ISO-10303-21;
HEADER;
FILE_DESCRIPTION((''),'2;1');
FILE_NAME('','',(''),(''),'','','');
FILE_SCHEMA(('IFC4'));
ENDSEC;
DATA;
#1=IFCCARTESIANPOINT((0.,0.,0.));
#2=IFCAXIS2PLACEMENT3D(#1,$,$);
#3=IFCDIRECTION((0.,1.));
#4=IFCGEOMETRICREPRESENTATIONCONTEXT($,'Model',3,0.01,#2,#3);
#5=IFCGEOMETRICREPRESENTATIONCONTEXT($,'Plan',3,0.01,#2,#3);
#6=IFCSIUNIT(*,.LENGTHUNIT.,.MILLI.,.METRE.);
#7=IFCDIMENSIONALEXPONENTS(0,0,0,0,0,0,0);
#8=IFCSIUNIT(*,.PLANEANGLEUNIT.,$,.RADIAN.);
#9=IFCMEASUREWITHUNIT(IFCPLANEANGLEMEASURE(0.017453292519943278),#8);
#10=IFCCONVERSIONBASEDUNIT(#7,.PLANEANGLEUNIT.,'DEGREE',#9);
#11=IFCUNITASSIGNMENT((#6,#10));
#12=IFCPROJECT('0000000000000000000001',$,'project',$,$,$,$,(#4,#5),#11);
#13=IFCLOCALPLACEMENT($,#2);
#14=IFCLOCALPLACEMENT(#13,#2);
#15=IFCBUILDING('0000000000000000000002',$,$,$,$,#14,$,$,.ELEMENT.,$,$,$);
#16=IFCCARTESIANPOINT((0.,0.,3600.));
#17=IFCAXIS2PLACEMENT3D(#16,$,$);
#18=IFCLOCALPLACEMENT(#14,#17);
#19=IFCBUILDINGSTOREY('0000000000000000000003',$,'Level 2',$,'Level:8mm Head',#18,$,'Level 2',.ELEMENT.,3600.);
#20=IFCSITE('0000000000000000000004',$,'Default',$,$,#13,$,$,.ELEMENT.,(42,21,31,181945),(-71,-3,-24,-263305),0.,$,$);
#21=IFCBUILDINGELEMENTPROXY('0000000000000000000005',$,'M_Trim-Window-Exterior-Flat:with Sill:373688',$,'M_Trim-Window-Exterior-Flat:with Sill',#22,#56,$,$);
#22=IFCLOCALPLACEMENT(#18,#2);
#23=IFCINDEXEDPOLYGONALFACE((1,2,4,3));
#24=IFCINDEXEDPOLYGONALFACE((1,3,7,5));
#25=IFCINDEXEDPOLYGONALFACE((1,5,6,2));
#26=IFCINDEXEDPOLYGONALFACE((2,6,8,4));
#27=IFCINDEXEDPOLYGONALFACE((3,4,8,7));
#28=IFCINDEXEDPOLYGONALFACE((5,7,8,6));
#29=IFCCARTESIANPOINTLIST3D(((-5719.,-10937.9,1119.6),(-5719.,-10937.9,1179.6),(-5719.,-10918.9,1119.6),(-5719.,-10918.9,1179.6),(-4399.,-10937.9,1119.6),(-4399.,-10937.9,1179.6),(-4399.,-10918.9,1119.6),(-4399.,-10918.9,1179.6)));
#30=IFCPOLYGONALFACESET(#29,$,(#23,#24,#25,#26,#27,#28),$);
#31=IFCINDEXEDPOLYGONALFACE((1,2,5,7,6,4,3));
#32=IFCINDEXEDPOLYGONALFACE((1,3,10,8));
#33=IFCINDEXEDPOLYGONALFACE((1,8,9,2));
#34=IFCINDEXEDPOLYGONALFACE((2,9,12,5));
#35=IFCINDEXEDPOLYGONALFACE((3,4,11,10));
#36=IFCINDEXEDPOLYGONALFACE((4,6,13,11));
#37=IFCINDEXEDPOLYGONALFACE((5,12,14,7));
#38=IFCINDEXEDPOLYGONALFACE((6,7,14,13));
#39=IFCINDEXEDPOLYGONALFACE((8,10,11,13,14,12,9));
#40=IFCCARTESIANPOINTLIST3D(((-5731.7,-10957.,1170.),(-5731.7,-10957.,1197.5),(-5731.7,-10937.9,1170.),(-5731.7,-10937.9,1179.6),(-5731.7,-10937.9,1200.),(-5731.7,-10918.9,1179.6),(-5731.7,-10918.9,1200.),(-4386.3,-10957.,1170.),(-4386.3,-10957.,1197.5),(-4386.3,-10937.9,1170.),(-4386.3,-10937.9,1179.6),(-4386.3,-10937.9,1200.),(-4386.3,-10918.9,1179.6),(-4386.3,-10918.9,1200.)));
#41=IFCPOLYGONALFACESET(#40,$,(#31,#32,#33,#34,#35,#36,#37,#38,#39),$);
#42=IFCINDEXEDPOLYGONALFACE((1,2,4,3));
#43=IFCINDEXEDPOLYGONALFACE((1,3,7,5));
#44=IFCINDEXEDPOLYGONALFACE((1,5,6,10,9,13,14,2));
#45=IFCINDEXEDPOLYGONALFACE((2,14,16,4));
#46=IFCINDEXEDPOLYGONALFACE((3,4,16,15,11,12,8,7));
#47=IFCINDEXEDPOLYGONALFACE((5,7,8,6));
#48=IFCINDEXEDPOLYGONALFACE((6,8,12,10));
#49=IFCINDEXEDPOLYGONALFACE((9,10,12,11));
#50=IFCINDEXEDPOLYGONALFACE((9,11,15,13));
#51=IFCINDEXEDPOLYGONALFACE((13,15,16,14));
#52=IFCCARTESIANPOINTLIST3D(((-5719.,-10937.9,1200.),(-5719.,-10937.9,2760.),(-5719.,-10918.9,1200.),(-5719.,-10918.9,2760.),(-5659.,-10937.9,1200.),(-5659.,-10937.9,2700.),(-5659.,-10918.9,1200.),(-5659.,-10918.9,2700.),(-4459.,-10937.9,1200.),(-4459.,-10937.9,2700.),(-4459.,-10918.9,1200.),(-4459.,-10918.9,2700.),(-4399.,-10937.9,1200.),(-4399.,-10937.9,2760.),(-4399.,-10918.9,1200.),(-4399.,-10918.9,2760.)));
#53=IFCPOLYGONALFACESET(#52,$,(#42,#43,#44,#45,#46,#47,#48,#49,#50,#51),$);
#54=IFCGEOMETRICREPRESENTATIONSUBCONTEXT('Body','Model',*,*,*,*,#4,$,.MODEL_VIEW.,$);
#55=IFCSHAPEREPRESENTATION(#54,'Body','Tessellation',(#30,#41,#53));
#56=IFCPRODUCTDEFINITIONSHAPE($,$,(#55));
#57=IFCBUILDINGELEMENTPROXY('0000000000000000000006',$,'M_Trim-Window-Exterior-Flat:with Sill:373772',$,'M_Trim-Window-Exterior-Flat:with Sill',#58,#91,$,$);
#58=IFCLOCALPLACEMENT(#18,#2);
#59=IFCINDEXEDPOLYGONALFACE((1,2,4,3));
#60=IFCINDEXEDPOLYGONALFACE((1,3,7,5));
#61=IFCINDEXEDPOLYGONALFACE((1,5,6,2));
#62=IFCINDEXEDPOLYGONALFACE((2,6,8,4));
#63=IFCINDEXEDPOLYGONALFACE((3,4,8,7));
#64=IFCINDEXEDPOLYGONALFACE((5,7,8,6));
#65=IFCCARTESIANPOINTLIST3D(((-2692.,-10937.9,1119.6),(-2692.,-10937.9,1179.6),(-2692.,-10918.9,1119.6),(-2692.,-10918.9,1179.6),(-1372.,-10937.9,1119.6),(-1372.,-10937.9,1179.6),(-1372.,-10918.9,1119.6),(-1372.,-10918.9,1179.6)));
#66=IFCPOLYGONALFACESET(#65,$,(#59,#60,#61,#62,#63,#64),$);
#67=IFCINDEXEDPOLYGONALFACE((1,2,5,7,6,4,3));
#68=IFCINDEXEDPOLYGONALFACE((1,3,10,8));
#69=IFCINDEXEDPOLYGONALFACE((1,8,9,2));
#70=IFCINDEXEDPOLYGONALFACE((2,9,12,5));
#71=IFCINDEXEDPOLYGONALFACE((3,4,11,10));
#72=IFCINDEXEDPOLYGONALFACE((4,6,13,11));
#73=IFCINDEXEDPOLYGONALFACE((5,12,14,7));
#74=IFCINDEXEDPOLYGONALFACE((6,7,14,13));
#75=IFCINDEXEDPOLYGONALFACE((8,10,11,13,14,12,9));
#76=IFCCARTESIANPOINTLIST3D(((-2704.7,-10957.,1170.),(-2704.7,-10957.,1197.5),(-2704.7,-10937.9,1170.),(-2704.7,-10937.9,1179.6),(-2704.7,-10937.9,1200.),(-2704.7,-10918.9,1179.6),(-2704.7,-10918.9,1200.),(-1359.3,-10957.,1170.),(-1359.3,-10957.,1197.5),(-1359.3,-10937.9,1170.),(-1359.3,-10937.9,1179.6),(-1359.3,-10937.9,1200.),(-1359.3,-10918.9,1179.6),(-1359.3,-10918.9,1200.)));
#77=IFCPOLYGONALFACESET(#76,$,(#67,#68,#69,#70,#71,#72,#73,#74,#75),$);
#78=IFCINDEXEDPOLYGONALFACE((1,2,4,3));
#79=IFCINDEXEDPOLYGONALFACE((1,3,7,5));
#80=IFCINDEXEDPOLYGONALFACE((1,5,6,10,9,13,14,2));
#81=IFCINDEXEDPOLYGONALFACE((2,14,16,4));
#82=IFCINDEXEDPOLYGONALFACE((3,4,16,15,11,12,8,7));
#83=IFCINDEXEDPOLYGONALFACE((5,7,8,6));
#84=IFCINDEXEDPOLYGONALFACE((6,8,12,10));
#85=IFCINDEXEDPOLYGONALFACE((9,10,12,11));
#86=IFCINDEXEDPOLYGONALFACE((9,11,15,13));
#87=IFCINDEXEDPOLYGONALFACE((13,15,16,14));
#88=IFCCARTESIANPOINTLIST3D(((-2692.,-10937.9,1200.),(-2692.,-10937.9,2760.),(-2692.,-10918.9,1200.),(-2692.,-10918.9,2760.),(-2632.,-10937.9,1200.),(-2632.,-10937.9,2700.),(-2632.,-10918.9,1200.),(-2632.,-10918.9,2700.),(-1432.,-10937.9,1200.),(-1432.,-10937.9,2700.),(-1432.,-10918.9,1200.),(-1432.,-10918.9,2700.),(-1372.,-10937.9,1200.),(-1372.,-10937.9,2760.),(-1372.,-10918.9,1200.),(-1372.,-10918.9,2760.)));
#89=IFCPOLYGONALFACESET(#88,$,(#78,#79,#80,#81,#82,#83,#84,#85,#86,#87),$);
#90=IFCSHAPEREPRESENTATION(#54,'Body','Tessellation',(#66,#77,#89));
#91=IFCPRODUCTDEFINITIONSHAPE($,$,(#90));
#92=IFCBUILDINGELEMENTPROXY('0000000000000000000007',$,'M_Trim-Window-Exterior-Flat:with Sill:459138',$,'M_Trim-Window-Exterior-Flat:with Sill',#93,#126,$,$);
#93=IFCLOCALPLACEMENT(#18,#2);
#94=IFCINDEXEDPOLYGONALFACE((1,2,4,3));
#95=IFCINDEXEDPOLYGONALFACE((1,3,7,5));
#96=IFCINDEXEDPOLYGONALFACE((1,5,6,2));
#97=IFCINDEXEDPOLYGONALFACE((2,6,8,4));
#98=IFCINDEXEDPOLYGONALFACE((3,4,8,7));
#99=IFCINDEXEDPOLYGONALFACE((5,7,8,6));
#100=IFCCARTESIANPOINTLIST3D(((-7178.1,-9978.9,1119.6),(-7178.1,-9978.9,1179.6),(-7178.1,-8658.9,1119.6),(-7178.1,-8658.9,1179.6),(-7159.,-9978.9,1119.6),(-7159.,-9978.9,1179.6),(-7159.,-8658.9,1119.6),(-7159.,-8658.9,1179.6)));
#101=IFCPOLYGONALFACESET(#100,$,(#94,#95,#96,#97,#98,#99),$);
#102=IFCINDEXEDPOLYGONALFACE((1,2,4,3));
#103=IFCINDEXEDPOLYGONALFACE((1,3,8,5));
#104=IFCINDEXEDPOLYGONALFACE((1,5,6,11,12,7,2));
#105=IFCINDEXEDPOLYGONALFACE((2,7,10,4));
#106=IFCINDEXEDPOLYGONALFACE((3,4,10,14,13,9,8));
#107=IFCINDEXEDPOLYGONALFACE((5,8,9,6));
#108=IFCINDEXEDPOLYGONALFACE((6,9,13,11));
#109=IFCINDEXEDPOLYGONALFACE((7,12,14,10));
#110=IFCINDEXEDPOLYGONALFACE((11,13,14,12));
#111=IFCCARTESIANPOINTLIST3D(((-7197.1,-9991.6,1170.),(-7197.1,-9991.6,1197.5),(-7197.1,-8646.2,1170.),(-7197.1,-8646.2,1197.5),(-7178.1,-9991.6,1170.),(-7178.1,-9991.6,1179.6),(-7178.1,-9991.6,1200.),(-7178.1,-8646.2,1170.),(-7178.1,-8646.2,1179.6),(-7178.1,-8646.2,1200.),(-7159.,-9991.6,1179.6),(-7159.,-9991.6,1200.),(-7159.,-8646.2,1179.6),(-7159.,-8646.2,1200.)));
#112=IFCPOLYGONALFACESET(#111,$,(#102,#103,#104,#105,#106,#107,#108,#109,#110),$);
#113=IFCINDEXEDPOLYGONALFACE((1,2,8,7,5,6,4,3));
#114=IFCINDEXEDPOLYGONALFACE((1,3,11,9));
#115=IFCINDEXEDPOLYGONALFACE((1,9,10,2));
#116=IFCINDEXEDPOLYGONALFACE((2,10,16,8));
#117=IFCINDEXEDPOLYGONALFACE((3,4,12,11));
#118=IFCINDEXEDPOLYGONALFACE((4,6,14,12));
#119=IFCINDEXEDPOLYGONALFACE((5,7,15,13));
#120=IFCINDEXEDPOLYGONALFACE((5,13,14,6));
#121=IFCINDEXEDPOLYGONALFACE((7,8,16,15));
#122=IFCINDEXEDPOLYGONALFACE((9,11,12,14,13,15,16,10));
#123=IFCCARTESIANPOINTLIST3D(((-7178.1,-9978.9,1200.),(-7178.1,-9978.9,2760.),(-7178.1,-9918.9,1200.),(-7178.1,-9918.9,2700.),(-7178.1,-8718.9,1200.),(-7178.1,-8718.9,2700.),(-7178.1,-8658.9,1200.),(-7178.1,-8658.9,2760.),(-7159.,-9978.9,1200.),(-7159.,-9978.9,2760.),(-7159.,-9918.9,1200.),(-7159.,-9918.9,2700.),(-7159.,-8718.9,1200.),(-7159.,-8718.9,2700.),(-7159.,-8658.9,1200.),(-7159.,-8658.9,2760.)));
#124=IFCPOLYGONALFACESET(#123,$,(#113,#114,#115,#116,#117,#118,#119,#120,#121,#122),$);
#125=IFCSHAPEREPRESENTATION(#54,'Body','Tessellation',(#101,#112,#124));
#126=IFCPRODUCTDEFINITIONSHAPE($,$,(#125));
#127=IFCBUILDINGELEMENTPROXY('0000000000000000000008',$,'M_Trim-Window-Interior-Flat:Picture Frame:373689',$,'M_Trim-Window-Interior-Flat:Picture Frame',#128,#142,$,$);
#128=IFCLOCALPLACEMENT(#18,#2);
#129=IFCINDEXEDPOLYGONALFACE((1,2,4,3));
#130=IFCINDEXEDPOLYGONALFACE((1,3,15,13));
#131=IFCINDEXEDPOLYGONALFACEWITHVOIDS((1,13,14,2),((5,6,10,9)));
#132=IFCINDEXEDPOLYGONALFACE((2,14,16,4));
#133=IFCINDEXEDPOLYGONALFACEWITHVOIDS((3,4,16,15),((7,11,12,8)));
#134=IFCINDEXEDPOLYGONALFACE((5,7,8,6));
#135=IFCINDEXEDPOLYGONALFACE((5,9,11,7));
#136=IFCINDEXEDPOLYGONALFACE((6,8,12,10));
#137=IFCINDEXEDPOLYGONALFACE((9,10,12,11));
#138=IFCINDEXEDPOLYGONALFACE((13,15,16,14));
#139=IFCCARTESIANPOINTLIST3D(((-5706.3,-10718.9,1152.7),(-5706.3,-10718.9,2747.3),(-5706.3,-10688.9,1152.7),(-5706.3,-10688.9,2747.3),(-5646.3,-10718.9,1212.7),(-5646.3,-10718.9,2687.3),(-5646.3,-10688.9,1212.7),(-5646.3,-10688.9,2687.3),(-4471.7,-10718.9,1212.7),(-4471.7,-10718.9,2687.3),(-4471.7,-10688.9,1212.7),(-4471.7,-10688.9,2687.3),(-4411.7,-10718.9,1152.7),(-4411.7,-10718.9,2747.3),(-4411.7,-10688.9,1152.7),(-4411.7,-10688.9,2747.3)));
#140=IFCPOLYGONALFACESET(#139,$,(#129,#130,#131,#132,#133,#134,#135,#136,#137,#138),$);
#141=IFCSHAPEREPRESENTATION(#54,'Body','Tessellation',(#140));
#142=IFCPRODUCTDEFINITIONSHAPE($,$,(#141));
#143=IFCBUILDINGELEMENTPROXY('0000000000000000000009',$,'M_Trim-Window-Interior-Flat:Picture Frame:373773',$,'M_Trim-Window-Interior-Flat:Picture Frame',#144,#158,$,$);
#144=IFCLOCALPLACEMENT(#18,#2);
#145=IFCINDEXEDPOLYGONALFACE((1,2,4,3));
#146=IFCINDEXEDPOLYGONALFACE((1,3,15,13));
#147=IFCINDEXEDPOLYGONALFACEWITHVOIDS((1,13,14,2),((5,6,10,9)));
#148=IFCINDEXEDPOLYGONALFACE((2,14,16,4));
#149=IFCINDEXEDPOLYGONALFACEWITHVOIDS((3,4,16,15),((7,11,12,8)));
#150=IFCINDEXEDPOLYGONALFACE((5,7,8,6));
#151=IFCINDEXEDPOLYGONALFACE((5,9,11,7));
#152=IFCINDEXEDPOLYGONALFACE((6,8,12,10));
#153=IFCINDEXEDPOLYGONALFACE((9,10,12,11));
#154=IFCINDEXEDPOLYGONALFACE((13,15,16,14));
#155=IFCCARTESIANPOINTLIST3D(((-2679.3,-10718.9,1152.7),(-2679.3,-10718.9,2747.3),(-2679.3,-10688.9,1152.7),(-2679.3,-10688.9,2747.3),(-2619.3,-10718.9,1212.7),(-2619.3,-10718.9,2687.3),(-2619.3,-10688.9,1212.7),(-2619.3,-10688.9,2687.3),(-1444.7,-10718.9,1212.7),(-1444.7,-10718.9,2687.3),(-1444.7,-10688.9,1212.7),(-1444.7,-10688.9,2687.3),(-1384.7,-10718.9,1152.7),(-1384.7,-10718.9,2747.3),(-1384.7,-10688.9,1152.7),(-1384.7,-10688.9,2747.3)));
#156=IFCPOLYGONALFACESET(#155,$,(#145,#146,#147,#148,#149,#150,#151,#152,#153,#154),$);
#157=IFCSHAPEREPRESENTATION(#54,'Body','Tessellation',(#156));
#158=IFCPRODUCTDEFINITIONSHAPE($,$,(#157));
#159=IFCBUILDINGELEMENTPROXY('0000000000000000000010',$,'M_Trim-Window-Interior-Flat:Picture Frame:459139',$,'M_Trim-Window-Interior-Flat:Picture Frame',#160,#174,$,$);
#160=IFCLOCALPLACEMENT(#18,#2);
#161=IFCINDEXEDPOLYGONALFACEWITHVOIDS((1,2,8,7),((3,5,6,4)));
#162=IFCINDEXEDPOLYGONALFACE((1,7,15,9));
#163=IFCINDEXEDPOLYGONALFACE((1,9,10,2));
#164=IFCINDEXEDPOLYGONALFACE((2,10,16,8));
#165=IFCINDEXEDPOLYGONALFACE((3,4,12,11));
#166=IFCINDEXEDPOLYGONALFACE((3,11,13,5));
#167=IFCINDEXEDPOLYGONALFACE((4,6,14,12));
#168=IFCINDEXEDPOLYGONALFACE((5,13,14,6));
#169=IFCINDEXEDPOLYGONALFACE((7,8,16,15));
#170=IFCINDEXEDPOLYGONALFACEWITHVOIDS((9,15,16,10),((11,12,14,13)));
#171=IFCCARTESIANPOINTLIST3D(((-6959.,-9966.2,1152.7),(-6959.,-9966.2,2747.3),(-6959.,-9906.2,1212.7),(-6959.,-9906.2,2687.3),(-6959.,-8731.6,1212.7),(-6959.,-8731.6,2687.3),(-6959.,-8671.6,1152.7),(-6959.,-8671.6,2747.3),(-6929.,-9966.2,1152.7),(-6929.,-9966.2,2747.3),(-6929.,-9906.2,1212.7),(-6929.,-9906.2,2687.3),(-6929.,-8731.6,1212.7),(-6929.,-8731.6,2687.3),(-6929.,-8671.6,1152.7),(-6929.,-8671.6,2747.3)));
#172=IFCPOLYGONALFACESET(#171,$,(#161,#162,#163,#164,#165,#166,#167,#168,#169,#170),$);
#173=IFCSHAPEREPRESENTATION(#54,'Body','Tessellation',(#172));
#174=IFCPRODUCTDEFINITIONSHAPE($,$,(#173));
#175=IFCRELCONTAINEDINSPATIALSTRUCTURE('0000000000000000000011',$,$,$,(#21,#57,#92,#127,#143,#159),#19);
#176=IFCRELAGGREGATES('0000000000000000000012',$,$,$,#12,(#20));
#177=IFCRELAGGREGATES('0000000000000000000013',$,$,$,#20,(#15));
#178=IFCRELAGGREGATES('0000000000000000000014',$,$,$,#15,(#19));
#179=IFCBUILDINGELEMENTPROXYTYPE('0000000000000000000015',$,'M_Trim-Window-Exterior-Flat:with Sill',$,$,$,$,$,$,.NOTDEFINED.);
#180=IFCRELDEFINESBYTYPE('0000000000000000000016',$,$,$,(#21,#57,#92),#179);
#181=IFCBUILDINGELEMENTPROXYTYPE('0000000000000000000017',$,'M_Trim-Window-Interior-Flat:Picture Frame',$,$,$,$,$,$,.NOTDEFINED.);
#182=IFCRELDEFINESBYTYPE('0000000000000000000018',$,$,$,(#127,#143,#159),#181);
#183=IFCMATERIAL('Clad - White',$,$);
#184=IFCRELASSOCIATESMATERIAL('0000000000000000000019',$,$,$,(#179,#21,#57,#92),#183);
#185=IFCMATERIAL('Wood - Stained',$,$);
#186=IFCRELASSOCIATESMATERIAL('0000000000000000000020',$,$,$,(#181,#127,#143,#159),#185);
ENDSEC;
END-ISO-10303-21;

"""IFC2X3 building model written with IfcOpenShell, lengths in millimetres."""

from ifc_helpers import new_model, entity, si_unit, converted_unit, direction, frame, frame_2d, origin, place, context, subcontext, project, spatial, polyline, rectangle, outline, extrude, source, transform, mapped, material, type_object, type_shapes, element, save


model = new_model("IFC2X3")

# Units and contexts
model_context = context("Model", 3, precision=0.01, world=origin(), true_north=direction((0.0, 1.0)))
plan_context = context("Plan", 3, precision=0.01, world=origin(), true_north=direction((0.0, 1.0)))
body_context = subcontext(model_context, "Body", "Model", "MODEL_VIEW")
ifc_project = project(units=[si_unit("LENGTHUNIT", "METRE", prefix="MILLI"), converted_unit("PLANEANGLEUNIT", "DEGREE", entity("IfcPlaneAngleMeasure", 0.017453292519943278), si_unit("PLANEANGLEUNIT", "RADIAN"), dimensions=[0, 0, 0, 0, 0, 0, 0])], contexts=[model_context, plan_context])

# Site, building, storey
site_placement = place(None, origin())
site = spatial("IfcSite", under=ifc_project, at=site_placement, Name="Default", CompositionType="ELEMENT", RefLatitude=(42, 21, 31, 181945), RefLongitude=(-71, -3, -24, -263305), RefElevation=0.0)
building_placement = place(site_placement, origin())
building = spatial("IfcBuilding", under=site, at=building_placement, CompositionType="ELEMENT")
storey_placement = place(building_placement, frame((0.0, 0.0, 3600.0)))
storey = spatial("IfcBuildingStorey", under=building, at=storey_placement, Name="Level 2", ObjectType="Level:8mm Head", LongName="Level 2", CompositionType="ELEMENT", Elevation=3600.0)

# Building element proxies
ifc_material_1 = material(Name="Clad - White")
ifc_material_2 = material(Name="Wood - Stained")
building_element_proxy_type_1 = type_object("IfcBuildingElementProxyType", Name="M_Trim-Window-Exterior-Flat:with Sill", PredefinedType="NOTDEFINED", material=ifc_material_1)
shared_shape_1 = source(origin(), body_context, "Body", "SweptSolid", [
    extrude(rectangle(XDim=1320.0, YDim=60.0, at=frame_2d((0.0, 0.0), x_axis=(1.0, 0.0))), frame((0.0, -1550.4, 0.0), z_axis=(0.0, 0.0, 1.0), x_axis=(-1.0, 0.0, 0.0)), (0.0, 0.0, 1.0), 19.0),
    extrude(outline(polyline([(-19.0, -15.2), (0.0, -15.2), (0.0, -5.7), (19.0, -5.7), (19.0, 14.8), (0.0, 14.8), (-19.0, 12.3), (-19.0, -15.2)])), frame((-672.7, -1514.8, 19.0), z_axis=(1.0, 0.0, 0.0), x_axis=(0.0, 0.0, -1.0)), (0.0, 0.0, 1.0), 1345.4),
    extrude(outline(polyline([(-795.0, -660.0), (765.0, -660.0), (765.0, -600.0), (-735.0, -600.0), (-735.0, 600.0), (765.0, 600.0), (765.0, 660.0), (-795.0, 660.0), (-795.0, -660.0)])), frame((0.0, -735.0, 0.0), z_axis=(0.0, 0.0, 1.0), x_axis=(0.0, -1.0, 0.0)), (0.0, 0.0, 1.0), 19.0),
])
type_shapes(building_element_proxy_type_1, [shared_shape_1])
for number, where, z_axis, x_axis, name in (
    (1, (-5059.0, -10918.9, 2700.0), (0.0, -1.0, 0.0), (1.0, 0.0, 0.0), "M_Trim-Window-Exterior-Flat:with Sill:373688"),
    (2, (-2032.0, -10918.9, 2700.0), (0.0, -1.0, 0.0), (1.0, 0.0, 0.0), "M_Trim-Window-Exterior-Flat:with Sill:373772"),
    (3, (-7159.0, -9318.9, 2700.0), (-1.0, 0.0, 0.0), (0.0, -1.0, 0.0), "M_Trim-Window-Exterior-Flat:with Sill:459138"),
):
    element("IfcBuildingElementProxy", number, at=place(storey_placement, frame(where, z_axis=z_axis, x_axis=x_axis)), inside=storey, type_object=building_element_proxy_type_1, material=ifc_material_1, Name=name, ObjectType="M_Trim-Window-Exterior-Flat:with Sill", context=body_context, shape_type="MappedRepresentation", body=[
        mapped(shared_shape_1, transform((0.0, 0.0, 0.0), scale=1.0)),
    ])
building_element_proxy_type_2 = type_object("IfcBuildingElementProxyType", Name="M_Trim-Window-Interior-Flat:Picture Frame", PredefinedType="NOTDEFINED", material=ifc_material_2)
shared_shape_2 = source(origin(), body_context, "Body", "SweptSolid", [
    extrude(outline(polyline([(-647.3, -797.3), (647.3, -797.3), (647.3, 797.3), (-647.3, 797.3), (-647.3, -797.3)]), holes=[polyline([(-587.3, -737.3), (-587.3, 737.3), (587.3, 737.3), (587.3, -737.3), (-587.3, -737.3)])]), frame((0.0, -750.0, 0.0), z_axis=(0.0, 0.0, 1.0), x_axis=(-1.0, 0.0, 0.0)), (0.0, 0.0, 1.0), 30.0),
])
type_shapes(building_element_proxy_type_2, [shared_shape_2])
for number, where, z_axis, x_axis, name in (
    (4, (-5059.0, -10718.9, 2700.0), (0.0, 1.0, 0.0), (-1.0, 0.0, 0.0), "M_Trim-Window-Interior-Flat:Picture Frame:373689"),
    (5, (-2032.0, -10718.9, 2700.0), (0.0, 1.0, 0.0), (-1.0, 0.0, 0.0), "M_Trim-Window-Interior-Flat:Picture Frame:373773"),
    (6, (-6959.0, -9318.9, 2700.0), (1.0, 0.0, 0.0), (0.0, 1.0, 0.0), "M_Trim-Window-Interior-Flat:Picture Frame:459139"),
):
    element("IfcBuildingElementProxy", number, at=place(storey_placement, frame(where, z_axis=z_axis, x_axis=x_axis)), inside=storey, type_object=building_element_proxy_type_2, material=ifc_material_2, Name=name, ObjectType="M_Trim-Window-Interior-Flat:Picture Frame", context=body_context, shape_type="MappedRepresentation", body=[
        mapped(shared_shape_2, transform((0.0, 0.0, 0.0), scale=1.0)),
    ])

save(model, "model.ifc")
